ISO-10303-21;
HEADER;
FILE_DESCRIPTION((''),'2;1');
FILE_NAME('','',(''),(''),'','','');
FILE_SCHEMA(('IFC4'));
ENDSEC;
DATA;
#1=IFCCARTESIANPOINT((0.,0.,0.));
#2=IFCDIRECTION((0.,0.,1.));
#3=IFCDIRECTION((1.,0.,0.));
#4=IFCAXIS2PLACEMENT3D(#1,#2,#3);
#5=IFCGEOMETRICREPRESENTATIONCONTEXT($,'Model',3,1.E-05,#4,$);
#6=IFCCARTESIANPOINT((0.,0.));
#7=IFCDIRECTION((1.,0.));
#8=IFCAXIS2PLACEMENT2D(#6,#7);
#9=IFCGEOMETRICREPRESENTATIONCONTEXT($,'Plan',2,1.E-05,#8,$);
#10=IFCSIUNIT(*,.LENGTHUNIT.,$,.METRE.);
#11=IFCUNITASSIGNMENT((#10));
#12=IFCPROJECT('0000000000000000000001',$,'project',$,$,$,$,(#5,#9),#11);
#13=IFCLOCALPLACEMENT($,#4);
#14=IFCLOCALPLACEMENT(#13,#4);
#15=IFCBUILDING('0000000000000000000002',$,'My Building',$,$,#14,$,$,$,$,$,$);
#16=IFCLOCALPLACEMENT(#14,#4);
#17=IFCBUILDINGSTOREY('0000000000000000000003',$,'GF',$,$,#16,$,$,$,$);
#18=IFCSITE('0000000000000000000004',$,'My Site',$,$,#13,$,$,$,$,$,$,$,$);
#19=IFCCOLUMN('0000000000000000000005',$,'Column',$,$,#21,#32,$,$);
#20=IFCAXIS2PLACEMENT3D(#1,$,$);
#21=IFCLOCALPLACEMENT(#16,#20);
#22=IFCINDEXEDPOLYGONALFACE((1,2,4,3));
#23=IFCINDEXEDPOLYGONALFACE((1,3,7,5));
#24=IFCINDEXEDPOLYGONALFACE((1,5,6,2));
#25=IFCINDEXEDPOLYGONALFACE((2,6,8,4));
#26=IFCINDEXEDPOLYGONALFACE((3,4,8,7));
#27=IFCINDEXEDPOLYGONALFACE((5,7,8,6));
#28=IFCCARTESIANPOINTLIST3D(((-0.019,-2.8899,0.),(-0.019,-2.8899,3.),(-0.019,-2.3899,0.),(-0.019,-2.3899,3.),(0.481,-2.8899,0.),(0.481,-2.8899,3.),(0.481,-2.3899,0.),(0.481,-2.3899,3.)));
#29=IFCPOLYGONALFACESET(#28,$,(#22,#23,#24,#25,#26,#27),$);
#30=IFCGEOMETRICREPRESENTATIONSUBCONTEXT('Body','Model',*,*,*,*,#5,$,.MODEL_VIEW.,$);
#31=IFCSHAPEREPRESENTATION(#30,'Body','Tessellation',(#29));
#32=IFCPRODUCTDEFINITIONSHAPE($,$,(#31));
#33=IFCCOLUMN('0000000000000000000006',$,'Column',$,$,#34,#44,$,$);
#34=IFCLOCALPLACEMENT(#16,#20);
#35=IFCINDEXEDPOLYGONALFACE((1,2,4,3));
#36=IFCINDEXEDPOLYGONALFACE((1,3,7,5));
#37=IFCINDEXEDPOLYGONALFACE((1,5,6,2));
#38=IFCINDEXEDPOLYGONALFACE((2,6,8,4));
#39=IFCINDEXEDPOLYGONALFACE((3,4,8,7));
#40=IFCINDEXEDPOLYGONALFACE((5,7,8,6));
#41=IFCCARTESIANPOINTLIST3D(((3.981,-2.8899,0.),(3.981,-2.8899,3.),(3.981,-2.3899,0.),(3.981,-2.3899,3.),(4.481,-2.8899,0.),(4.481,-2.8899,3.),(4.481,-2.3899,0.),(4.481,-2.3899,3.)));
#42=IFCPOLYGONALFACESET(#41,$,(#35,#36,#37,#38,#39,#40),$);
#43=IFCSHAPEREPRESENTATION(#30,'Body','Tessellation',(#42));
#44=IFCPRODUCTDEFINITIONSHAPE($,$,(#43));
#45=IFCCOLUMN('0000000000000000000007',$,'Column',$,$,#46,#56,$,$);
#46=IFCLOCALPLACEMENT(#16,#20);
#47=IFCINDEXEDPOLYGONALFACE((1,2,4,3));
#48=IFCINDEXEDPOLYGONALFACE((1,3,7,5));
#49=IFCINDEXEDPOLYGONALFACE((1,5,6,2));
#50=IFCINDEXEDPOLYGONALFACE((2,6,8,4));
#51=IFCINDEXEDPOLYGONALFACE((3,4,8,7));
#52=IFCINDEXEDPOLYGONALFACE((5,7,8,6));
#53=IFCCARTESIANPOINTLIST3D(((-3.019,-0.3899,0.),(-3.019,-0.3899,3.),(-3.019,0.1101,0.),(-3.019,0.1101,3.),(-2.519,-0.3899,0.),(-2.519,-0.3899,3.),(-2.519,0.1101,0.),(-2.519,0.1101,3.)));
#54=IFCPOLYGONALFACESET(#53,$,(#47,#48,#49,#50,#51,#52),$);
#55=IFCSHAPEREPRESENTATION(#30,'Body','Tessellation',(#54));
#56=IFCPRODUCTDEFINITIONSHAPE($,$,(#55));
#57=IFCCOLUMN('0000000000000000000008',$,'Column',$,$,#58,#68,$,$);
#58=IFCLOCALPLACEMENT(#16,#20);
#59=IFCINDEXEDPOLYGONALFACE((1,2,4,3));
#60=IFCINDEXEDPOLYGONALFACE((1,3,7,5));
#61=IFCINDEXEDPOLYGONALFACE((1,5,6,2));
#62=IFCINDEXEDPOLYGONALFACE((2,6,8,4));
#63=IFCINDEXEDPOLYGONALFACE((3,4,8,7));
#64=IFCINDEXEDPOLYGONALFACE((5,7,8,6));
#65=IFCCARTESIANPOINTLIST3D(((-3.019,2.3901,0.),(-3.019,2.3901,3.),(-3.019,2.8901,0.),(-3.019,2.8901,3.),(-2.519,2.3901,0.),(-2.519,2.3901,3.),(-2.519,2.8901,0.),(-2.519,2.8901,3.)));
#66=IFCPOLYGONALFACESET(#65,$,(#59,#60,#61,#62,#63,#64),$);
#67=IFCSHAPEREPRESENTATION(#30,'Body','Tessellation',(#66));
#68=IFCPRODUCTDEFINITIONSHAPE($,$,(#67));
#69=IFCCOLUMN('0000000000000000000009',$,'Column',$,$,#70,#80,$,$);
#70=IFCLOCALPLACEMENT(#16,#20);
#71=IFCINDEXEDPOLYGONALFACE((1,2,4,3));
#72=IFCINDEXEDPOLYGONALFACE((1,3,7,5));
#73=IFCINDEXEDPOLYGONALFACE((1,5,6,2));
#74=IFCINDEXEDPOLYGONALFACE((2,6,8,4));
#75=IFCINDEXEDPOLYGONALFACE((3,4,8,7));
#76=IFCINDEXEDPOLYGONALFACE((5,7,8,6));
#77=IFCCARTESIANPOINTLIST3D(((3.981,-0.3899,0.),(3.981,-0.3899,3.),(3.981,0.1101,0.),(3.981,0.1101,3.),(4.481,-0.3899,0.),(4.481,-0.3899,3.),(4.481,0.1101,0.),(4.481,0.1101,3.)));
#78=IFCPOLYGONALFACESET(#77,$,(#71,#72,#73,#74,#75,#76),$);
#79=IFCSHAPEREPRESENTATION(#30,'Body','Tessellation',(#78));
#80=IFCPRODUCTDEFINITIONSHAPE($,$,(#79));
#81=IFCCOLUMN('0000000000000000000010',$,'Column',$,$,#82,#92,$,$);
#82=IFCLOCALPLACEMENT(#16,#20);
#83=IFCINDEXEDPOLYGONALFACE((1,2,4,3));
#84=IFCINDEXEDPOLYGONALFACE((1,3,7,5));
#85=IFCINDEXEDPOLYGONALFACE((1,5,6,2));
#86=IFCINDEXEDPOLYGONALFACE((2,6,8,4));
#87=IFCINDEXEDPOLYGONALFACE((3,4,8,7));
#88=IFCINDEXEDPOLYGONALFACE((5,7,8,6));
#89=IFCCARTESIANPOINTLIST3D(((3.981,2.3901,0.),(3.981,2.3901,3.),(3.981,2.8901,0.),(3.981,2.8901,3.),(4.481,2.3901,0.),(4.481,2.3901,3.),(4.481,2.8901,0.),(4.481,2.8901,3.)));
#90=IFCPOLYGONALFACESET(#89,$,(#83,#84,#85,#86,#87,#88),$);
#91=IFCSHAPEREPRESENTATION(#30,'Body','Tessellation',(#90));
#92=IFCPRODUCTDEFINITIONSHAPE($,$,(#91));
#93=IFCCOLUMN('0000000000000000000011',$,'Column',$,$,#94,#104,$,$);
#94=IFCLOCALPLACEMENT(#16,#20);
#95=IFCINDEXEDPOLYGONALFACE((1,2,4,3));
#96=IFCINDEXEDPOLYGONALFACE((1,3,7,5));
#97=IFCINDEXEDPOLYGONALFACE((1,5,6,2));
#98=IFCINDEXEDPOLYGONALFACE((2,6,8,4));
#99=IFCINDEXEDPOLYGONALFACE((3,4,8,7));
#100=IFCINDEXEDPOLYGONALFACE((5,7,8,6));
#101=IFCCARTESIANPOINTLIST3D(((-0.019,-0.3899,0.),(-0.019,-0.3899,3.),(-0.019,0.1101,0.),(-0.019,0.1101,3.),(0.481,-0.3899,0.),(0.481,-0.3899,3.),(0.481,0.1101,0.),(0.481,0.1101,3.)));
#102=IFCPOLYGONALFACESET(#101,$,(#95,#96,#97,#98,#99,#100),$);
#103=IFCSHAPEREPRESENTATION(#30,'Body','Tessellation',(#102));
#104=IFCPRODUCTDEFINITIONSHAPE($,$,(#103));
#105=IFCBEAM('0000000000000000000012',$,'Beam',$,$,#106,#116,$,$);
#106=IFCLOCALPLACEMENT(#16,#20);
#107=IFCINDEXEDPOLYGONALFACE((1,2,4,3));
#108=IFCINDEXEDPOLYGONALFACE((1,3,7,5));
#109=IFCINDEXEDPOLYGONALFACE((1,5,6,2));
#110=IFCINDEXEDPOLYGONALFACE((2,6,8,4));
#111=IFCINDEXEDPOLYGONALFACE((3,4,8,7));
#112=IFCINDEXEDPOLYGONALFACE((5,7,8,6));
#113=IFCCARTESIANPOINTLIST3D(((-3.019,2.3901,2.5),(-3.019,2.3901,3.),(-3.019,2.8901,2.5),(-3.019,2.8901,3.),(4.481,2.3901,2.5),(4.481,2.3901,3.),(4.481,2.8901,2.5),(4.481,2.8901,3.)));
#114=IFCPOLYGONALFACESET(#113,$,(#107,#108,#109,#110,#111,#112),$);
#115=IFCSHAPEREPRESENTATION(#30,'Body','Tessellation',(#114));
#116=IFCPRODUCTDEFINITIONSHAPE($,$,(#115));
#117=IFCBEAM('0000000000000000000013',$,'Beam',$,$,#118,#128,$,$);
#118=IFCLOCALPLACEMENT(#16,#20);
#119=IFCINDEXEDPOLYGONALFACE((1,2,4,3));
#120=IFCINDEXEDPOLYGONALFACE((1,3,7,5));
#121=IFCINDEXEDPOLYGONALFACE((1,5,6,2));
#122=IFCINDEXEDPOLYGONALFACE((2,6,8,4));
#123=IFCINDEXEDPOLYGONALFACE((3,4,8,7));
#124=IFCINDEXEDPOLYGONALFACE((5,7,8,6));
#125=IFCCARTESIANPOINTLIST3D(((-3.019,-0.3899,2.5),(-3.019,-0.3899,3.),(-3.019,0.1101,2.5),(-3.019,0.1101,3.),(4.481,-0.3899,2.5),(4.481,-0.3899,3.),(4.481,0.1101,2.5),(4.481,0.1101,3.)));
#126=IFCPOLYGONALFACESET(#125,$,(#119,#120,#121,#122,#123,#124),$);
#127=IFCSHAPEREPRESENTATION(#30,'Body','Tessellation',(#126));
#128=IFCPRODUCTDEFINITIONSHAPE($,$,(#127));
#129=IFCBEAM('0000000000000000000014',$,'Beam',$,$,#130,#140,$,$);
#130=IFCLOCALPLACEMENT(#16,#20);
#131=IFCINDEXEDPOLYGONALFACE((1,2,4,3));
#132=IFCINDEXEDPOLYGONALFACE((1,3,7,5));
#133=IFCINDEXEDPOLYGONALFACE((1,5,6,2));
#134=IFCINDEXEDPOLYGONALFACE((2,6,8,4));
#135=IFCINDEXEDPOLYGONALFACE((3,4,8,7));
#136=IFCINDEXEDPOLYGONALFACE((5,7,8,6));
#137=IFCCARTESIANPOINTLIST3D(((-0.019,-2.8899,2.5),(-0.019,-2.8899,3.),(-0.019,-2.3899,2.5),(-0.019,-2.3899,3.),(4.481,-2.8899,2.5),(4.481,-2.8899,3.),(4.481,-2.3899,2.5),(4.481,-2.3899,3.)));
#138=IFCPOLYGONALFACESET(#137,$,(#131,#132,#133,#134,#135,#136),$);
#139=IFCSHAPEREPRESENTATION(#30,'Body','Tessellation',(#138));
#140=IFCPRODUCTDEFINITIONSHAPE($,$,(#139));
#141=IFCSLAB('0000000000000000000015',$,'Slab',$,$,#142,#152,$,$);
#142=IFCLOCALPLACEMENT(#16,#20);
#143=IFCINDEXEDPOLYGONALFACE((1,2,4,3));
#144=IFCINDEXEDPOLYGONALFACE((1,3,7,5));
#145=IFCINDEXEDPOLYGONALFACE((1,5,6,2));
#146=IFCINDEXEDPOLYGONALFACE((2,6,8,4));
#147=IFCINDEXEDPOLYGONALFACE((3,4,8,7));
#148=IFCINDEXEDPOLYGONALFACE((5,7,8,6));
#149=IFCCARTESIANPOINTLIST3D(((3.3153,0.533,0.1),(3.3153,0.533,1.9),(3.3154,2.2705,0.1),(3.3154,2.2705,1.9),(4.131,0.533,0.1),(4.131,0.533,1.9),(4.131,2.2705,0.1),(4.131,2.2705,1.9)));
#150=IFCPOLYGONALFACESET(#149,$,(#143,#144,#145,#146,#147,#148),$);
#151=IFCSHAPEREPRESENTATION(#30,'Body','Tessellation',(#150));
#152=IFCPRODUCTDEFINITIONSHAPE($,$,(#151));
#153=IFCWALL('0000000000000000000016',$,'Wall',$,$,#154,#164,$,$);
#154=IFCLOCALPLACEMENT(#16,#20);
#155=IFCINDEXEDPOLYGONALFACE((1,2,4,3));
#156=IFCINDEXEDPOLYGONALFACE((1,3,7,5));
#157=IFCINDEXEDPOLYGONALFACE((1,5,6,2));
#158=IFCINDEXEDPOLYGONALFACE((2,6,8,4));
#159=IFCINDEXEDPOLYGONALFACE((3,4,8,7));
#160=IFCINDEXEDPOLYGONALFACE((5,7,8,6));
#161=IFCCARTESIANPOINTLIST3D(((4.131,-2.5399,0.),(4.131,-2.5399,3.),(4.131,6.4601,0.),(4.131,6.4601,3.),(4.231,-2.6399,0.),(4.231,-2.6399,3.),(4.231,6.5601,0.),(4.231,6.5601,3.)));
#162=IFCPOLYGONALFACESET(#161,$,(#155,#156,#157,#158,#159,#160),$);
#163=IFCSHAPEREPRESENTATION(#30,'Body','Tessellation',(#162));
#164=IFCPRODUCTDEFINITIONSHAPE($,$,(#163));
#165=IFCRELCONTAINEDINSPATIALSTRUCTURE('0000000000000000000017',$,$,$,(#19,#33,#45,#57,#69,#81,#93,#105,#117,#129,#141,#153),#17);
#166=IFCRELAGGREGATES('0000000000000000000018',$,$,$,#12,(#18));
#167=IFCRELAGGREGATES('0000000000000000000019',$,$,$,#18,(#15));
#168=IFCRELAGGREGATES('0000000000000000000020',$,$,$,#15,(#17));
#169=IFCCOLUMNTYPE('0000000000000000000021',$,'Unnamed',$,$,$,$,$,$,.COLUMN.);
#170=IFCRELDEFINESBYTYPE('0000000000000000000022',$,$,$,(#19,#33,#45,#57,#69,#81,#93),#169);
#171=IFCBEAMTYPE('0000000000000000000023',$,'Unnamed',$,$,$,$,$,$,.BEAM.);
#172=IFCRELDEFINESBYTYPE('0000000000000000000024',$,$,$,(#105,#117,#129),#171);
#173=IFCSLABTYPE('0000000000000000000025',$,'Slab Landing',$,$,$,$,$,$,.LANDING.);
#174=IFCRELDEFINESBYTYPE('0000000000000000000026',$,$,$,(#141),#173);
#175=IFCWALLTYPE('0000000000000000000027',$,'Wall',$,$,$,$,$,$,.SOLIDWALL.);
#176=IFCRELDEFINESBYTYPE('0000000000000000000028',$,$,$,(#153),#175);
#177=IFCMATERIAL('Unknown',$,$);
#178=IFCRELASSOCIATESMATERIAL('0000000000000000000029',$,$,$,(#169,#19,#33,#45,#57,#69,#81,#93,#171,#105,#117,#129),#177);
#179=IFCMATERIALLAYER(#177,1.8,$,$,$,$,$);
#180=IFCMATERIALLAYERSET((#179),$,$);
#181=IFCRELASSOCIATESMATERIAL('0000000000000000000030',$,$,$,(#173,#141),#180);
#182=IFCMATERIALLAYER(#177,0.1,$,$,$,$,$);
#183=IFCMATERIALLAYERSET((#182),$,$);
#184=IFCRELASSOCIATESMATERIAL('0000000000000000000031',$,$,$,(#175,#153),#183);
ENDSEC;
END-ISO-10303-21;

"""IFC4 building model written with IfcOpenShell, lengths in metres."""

from ifc_helpers import new_model, si_unit, frame, origin_with_axes, origin_2d_with_axis, place, context, subcontext, project, spatial, line, indexed_curve, rectangle, outline, extrude, material, layer, layer_set, layer_usage, material_profile, profile_set, profile_usage, type_object, element, save


model = new_model("IFC4")

# Units and contexts
model_context = context("Model", 3, precision=1e-05, world=origin_with_axes())
plan_context = context("Plan", 2, precision=1e-05, world=origin_2d_with_axis())
body_context_1 = subcontext(model_context, "Body", "Model", "MODEL_VIEW")
ifc_project = project(units=[si_unit("LENGTHUNIT", "METRE")], contexts=[model_context, plan_context])

# Site, building, storey
site_placement = place(None, origin_with_axes())
site = spatial("IfcSite", under=ifc_project, at=site_placement, Name="My Site")
building_placement = place(site_placement, origin_with_axes())
building = spatial("IfcBuilding", under=site, at=building_placement, Name="My Building")
storey_placement = place(building_placement, origin_with_axes())
storey = spatial("IfcBuildingStorey", under=building, at=storey_placement, Name="GF")

# Columns
ifc_material = material(Name="Unknown")
ifc_material_profile_1 = material_profile(ifc_material, rectangle(XDim=0.5, YDim=0.5))
ifc_profile_set_1 = profile_set([ifc_material_profile_1])
ifc_profile_usage_1 = profile_usage(ifc_profile_set_1, cardinal=5)
column_type = type_object("IfcColumnType", Name="Unnamed", PredefinedType="COLUMN", material=ifc_profile_set_1)
column_1_placement = place(storey_placement, frame((0.231, -2.6399, 0.0), z_axis=(0.0, 0.0, 1.0), x_axis=(1.0, 0.0, 0.0)))
element("IfcColumn", 1, at=column_1_placement, inside=storey, type_object=column_type, material=ifc_profile_usage_1, Name="Column", context=body_context_1, shape_type="SweptSolid", body=[
    extrude(rectangle(XDim=0.5, YDim=0.5), origin_with_axes(), (0.0, 0.0, 1.0), 3.0),
])
ifc_profile_usage_2 = profile_usage(ifc_profile_set_1, cardinal=5)
column_2_placement = place(storey_placement, frame((4.231, -2.6399, 0.0), z_axis=(0.0, 0.0, 1.0), x_axis=(1.0, 0.0, 0.0)))
element("IfcColumn", 2, at=column_2_placement, inside=storey, type_object=column_type, material=ifc_profile_usage_2, Name="Column", context=body_context_1, shape_type="SweptSolid", body=[
    extrude(rectangle(XDim=0.5, YDim=0.5), origin_with_axes(), (0.0, 0.0, 1.0), 3.0),
])
ifc_profile_usage_3 = profile_usage(ifc_profile_set_1, cardinal=5)
column_3_placement = place(storey_placement, frame((-2.769, -0.1399, 0.0), z_axis=(0.0, 0.0, 1.0), x_axis=(1.0, 0.0, 0.0)))
element("IfcColumn", 3, at=column_3_placement, inside=storey, type_object=column_type, material=ifc_profile_usage_3, Name="Column", context=body_context_1, shape_type="SweptSolid", body=[
    extrude(rectangle(XDim=0.5, YDim=0.5), origin_with_axes(), (0.0, 0.0, 1.0), 3.0),
])
ifc_profile_usage_4 = profile_usage(ifc_profile_set_1, cardinal=5)
column_4_placement = place(storey_placement, frame((-2.769, 2.6401, 0.0), z_axis=(0.0, 0.0, 1.0), x_axis=(1.0, 0.0, 0.0)))
element("IfcColumn", 4, at=column_4_placement, inside=storey, type_object=column_type, material=ifc_profile_usage_4, Name="Column", context=body_context_1, shape_type="SweptSolid", body=[
    extrude(rectangle(XDim=0.5, YDim=0.5), origin_with_axes(), (0.0, 0.0, 1.0), 3.0),
])
ifc_profile_usage_5 = profile_usage(ifc_profile_set_1, cardinal=5)
column_5_placement = place(storey_placement, frame((4.231, -0.1399, 0.0), z_axis=(0.0, 0.0, 1.0), x_axis=(1.0, 0.0, 0.0)))
element("IfcColumn", 5, at=column_5_placement, inside=storey, type_object=column_type, material=ifc_profile_usage_5, Name="Column", context=body_context_1, shape_type="SweptSolid", body=[
    extrude(rectangle(XDim=0.5, YDim=0.5), origin_with_axes(), (0.0, 0.0, 1.0), 3.0),
])
ifc_profile_usage_6 = profile_usage(ifc_profile_set_1, cardinal=5)
column_6_placement = place(storey_placement, frame((4.231, 2.6401, 0.0), z_axis=(0.0, 0.0, 1.0), x_axis=(1.0, 0.0, 0.0)))
element("IfcColumn", 6, at=column_6_placement, inside=storey, type_object=column_type, material=ifc_profile_usage_6, Name="Column", context=body_context_1, shape_type="SweptSolid", body=[
    extrude(rectangle(XDim=0.5, YDim=0.5), origin_with_axes(), (0.0, 0.0, 1.0), 3.0),
])
ifc_profile_usage_7 = profile_usage(ifc_profile_set_1, cardinal=5)
column_7_placement = place(storey_placement, frame((0.231, -0.1399, 0.0), z_axis=(0.0, 0.0, 1.0), x_axis=(1.0, 0.0, 0.0)))
element("IfcColumn", 7, at=column_7_placement, inside=storey, type_object=column_type, material=ifc_profile_usage_7, Name="Column", context=body_context_1, shape_type="SweptSolid", body=[
    extrude(rectangle(XDim=0.5, YDim=0.5), origin_with_axes(), (0.0, 0.0, 1.0), 3.0),
])

# Beams
ifc_material_profile_2 = material_profile(ifc_material, rectangle(XDim=0.5, YDim=0.5))
ifc_profile_set_2 = profile_set([ifc_material_profile_2])
ifc_profile_usage_8 = profile_usage(ifc_profile_set_2, cardinal=7)
beam_type = type_object("IfcBeamType", Name="Unnamed", PredefinedType="BEAM", material=ifc_profile_set_2)
beam_1_placement = place(storey_placement, frame((4.481, 2.3901, 3.0), z_axis=(-1.0, 0.0, 0.0), x_axis=(0.0, -1.0, 0.0)))
element("IfcBeam", 8, at=beam_1_placement, inside=storey, type_object=beam_type, material=ifc_profile_usage_8, Name="Beam", context=body_context_1, shape_type="SweptSolid", body=[
    extrude(rectangle(XDim=0.5, YDim=0.5), frame((-0.25, -0.25, 0.0), z_axis=(0.0, 0.0, 1.0), x_axis=(1.0, 0.0, 0.0)), (0.0, 0.0, 1.0), 7.5),
])
ifc_profile_usage_9 = profile_usage(ifc_profile_set_2, cardinal=7)
beam_2_placement = place(storey_placement, frame((4.481, -0.3899, 3.0), z_axis=(-1.0, 0.0, 0.0), x_axis=(0.0, -1.0, 0.0)))
element("IfcBeam", 9, at=beam_2_placement, inside=storey, type_object=beam_type, material=ifc_profile_usage_9, Name="Beam", context=body_context_1, shape_type="SweptSolid", body=[
    extrude(rectangle(XDim=0.5, YDim=0.5), frame((-0.25, -0.25, 0.0), z_axis=(0.0, 0.0, 1.0), x_axis=(1.0, 0.0, 0.0)), (0.0, 0.0, 1.0), 7.5),
])
ifc_profile_usage_10 = profile_usage(ifc_profile_set_2, cardinal=7)
beam_3_placement = place(storey_placement, frame((4.481, -2.8899, 3.0), z_axis=(-1.0, -0.000001, 0.000001), x_axis=(0.000001, -1.0, 0.0)))
element("IfcBeam", 10, at=beam_3_placement, inside=storey, type_object=beam_type, material=ifc_profile_usage_10, Name="Beam", context=body_context_1, shape_type="SweptSolid", body=[
    extrude(rectangle(XDim=0.5, YDim=0.5), frame((-0.25, -0.25, 0.0), z_axis=(0.0, 0.0, 1.0), x_axis=(1.0, 0.0, 0.0)), (0.0, 0.0, 1.0), 4.5),
])

# Slab
ifc_layer_1 = layer(ifc_material, 1.8)
ifc_layer_set_1 = layer_set([ifc_layer_1])
ifc_layer_usage_1 = layer_usage(ifc_layer_set_1, "AXIS3", "POSITIVE", -0.1)
slab_type_1 = type_object("IfcSlabType", Name="Slab Landing", PredefinedType="LANDING", material=ifc_layer_set_1)
slab_1_placement = place(storey_placement, frame((3.3153, 0.533, 0.2), z_axis=(0.0, 0.0, 1.0), x_axis=(1.0, 0.0, 0.0)))
element("IfcSlab", 11, at=slab_1_placement, inside=storey, type_object=slab_type_1, material=ifc_layer_usage_1, Name="Slab", context=body_context_1, shape_type="SweptSolid", body=[
    extrude(outline(indexed_curve([(0.0, 1.7375), (0.8156, 1.7375), (0.8156, 0.0), (0.0, 0.0), (0.0, 1.7375)])), frame((0.0, 0.0, -0.1), z_axis=(0.0, 0.0, 1.0), x_axis=(1.0, 0.0, 0.0)), (0.0, 0.0, 1.0), 1.8),
])

# Shared definitions
ifc_layer_2 = layer(ifc_material, 0.1)
ifc_layer_set_2 = layer_set([ifc_layer_2])
wall_type = type_object("IfcWallType", Name="Wall", PredefinedType="SOLIDWALL", material=ifc_layer_set_2)

# Wall
ifc_layer_usage_2 = layer_usage(ifc_layer_set_2, "AXIS2", "POSITIVE", 0.0)
wall_1_placement = place(storey_placement, frame((4.231, -2.6399, 0.0), z_axis=(0.0, 0.0, 1.0), x_axis=(0.0, 1.0, 0.0)))
element("IfcWall", 12, at=wall_1_placement, inside=storey, type_object=wall_type, material=ifc_layer_usage_2, Name="Wall", context=body_context_1, shape_type="SweptSolid", body=[
    extrude(outline(indexed_curve([(0.0, 0.0), (0.1, 0.1), (9.1, 0.1), (9.2, 0.0)], segments=[line(1, 2, 3, 4, 1)])), origin_with_axes(), (0.0, 0.0, 1.0), 3.0),
])

save(model, "model.ifc")
